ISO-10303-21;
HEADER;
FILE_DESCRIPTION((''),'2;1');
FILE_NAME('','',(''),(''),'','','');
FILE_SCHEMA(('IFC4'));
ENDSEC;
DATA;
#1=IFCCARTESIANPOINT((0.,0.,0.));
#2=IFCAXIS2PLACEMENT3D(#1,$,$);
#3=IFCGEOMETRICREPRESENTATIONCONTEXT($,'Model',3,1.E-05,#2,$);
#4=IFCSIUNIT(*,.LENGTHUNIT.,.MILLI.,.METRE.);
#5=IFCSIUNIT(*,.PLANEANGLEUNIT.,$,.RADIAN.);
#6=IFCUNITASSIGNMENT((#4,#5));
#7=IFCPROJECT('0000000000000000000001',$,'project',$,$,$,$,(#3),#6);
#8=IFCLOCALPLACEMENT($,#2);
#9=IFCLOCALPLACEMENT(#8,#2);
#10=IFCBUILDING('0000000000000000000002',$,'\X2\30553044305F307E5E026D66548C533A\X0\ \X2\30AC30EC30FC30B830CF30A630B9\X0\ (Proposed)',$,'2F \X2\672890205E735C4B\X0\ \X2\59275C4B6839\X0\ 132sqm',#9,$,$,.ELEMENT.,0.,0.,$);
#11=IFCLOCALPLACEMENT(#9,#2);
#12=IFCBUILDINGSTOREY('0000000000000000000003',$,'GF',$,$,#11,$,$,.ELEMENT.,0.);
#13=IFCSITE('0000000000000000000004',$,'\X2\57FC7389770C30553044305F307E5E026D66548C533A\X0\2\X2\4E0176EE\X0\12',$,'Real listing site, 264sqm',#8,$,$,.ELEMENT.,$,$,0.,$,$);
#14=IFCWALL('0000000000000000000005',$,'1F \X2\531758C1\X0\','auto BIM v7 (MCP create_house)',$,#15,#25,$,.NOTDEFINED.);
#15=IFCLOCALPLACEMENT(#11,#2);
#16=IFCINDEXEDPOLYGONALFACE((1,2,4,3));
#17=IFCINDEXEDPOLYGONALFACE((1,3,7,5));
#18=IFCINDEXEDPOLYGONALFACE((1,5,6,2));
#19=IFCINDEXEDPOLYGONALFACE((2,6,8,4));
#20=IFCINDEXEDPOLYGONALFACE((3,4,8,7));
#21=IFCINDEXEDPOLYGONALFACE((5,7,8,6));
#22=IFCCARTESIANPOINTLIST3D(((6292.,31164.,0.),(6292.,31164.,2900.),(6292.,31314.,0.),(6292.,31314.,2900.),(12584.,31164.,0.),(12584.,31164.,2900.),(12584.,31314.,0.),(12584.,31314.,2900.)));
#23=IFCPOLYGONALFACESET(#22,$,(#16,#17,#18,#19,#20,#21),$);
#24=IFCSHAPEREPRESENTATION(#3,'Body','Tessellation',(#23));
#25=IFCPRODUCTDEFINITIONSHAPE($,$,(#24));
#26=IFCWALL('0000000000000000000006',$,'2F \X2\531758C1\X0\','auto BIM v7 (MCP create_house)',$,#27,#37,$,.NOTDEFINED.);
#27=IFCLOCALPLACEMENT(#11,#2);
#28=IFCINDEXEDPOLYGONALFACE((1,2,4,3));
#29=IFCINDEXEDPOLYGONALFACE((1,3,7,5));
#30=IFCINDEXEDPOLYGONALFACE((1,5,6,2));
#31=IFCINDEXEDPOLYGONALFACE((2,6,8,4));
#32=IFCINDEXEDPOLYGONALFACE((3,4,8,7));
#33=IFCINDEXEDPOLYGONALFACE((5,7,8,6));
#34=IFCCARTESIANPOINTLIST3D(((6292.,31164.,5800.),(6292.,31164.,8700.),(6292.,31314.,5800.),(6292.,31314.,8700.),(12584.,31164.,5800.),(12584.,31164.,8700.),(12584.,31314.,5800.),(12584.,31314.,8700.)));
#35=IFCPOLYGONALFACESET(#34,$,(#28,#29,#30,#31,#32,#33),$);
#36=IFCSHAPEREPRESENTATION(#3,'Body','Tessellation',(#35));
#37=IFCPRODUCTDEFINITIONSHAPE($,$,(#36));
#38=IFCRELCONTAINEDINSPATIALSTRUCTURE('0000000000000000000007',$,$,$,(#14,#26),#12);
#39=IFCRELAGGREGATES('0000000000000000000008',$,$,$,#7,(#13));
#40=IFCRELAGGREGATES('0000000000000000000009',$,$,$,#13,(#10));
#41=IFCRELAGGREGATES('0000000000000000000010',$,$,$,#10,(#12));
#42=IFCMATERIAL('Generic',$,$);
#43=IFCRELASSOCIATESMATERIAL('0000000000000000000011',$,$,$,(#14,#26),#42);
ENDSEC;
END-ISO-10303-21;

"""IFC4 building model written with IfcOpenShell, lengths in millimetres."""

from ifc_helpers import new_model, si_unit, frame, frame_2d, origin, place, context, project, spatial, rectangle, extrude, material, element, save


model = new_model("IFC4")

# Units and contexts
model_context = context("Model", 3, precision=1e-05, world=origin())
ifc_project = project(units=[si_unit("LENGTHUNIT", "METRE", prefix="MILLI"), si_unit("PLANEANGLEUNIT", "RADIAN")], contexts=[model_context])

# Site, building, storey
site_placement = place(None, origin())
site = spatial("IfcSite", under=ifc_project, at=site_placement, Name="埼玉県さいたま市浦和区2丁目12", ObjectType="Real listing site, 264sqm", CompositionType="ELEMENT", RefElevation=0.0)
building_placement = place(site_placement, origin())
building = spatial("IfcBuilding", under=site, at=building_placement, Name="さいたま市浦和区 ガレージハウス (Proposed)", ObjectType="2F 木造平屋 大屋根 132sqm", CompositionType="ELEMENT", ElevationOfRefHeight=0.0, ElevationOfTerrain=0.0)
storey_placement = place(building_placement, origin())
storey = spatial("IfcBuildingStorey", under=building, at=storey_placement, Name="GF", CompositionType="ELEMENT", Elevation=0.0)

# Shared definitions
ifc_material = material(Name="Generic")

# Wall
wall_1_placement = place(storey_placement, frame((3146.0, 15582.0, 0.0)))
element("IfcWall", 1, at=wall_1_placement, inside=storey, material=ifc_material, Name="1F 北壁", Description="auto BIM v7 (MCP create_house)", PredefinedType="NOTDEFINED", context=model_context, shape_type="SweptSolid", body=[
    extrude(rectangle(XDim=6292.0, YDim=150.0, at=frame_2d((3146.0, 75.0))), frame((3146.0, 15582.0, 0.0)), (0.0, 0.0, 1.0), 2900.0),
])

# Wall
wall_2_placement = place(storey_placement, frame((3146.0, 15582.0, 2900.0)))
element("IfcWall", 2, at=wall_2_placement, inside=storey, material=ifc_material, Name="2F 北壁", Description="auto BIM v7 (MCP create_house)", PredefinedType="NOTDEFINED", context=model_context, shape_type="SweptSolid", body=[
    extrude(rectangle(XDim=6292.0, YDim=150.0, at=frame_2d((3146.0, 75.0))), frame((3146.0, 15582.0, 2900.0)), (0.0, 0.0, 1.0), 2900.0),
])

save(model, "model.ifc")
